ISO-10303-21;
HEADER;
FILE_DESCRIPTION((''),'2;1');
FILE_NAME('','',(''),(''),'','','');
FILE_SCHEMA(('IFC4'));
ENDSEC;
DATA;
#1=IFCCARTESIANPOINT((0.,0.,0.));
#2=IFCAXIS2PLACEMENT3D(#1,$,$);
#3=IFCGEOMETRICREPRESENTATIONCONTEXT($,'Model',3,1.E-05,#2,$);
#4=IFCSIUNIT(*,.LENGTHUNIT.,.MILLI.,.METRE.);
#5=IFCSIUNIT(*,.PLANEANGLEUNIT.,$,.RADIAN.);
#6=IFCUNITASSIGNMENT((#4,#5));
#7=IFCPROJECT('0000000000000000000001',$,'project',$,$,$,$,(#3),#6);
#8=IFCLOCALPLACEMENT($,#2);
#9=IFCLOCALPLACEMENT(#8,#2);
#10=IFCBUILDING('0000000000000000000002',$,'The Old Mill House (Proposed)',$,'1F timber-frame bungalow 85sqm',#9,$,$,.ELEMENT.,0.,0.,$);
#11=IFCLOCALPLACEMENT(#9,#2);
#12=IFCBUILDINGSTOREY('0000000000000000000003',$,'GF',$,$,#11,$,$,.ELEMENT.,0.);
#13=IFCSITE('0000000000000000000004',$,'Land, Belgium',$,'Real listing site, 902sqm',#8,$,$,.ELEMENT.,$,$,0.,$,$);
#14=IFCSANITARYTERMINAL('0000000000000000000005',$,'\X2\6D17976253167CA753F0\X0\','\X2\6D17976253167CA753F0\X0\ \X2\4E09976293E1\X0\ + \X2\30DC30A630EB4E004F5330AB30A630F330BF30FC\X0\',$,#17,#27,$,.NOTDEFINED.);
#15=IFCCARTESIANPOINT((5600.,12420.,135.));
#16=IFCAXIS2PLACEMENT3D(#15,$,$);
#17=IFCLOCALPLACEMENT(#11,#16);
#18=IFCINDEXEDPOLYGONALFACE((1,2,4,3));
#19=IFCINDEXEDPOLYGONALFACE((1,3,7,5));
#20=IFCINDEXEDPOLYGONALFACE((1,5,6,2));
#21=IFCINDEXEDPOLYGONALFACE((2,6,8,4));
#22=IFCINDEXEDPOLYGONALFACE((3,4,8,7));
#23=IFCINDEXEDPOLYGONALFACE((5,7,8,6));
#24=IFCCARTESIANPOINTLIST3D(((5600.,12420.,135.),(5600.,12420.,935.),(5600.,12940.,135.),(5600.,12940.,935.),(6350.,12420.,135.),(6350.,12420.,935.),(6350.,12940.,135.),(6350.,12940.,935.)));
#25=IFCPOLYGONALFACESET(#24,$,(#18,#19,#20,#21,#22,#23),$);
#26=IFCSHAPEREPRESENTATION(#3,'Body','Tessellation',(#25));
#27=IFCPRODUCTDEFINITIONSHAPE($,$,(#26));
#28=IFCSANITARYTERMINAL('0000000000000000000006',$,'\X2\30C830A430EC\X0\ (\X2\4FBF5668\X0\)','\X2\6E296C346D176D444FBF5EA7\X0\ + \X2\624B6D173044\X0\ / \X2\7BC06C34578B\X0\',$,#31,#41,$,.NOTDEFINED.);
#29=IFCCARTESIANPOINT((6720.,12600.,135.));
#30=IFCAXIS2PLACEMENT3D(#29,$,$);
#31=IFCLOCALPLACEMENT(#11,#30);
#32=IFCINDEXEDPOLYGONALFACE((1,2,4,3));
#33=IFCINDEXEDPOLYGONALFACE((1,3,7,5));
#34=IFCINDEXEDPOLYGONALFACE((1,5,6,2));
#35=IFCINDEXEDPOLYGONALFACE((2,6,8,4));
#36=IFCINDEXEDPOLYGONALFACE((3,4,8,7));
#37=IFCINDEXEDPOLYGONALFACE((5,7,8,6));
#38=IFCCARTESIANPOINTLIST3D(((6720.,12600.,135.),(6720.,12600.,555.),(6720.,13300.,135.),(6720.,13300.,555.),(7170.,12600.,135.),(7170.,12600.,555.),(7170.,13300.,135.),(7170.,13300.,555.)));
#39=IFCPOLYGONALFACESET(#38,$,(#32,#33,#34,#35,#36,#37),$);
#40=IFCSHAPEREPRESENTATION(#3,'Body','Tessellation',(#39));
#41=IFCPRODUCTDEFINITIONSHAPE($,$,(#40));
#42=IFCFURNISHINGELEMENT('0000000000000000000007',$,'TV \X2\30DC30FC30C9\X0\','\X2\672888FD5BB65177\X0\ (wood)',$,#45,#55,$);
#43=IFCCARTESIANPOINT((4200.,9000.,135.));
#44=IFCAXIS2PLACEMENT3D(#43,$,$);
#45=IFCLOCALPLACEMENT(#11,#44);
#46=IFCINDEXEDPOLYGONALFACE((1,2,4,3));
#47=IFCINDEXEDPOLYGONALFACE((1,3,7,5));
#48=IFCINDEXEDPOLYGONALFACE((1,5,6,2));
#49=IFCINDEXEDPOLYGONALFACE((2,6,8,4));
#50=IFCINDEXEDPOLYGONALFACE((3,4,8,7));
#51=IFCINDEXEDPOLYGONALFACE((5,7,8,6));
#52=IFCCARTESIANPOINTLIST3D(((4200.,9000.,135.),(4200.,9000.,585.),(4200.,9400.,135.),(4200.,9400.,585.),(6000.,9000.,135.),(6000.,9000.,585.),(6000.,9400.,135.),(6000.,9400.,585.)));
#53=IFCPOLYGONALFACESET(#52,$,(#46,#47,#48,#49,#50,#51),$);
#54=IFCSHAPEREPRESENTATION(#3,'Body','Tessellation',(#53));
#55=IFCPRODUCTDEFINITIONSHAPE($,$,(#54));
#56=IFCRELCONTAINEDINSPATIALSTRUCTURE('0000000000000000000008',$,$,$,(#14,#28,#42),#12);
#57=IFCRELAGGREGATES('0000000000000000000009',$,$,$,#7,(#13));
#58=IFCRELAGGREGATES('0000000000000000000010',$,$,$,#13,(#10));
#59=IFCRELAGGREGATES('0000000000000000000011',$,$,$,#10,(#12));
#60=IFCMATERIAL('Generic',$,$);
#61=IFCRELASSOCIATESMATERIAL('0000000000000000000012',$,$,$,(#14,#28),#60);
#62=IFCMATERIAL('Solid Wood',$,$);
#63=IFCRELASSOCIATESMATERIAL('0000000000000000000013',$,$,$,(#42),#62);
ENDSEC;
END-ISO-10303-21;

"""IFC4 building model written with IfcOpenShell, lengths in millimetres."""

from ifc_helpers import new_model, si_unit, frame, frame_2d, origin, place, context, project, spatial, rectangle, extrude, material, element, save


model = new_model("IFC4")

# Units and contexts
model_context = context("Model", 3, precision=1e-05, world=origin())
ifc_project = project(units=[si_unit("LENGTHUNIT", "METRE", prefix="MILLI"), si_unit("PLANEANGLEUNIT", "RADIAN")], contexts=[model_context])

# Site, building, storey
site_placement = place(None, origin())
site = spatial("IfcSite", under=ifc_project, at=site_placement, Name="Land, Belgium", ObjectType="Real listing site, 902sqm", CompositionType="ELEMENT", RefElevation=0.0)
building_placement = place(site_placement, origin())
building = spatial("IfcBuilding", under=site, at=building_placement, Name="The Old Mill House (Proposed)", ObjectType="1F timber-frame bungalow 85sqm", CompositionType="ELEMENT", ElevationOfRefHeight=0.0, ElevationOfTerrain=0.0)
storey_placement = place(building_placement, origin())
storey = spatial("IfcBuildingStorey", under=building, at=storey_placement, Name="GF", CompositionType="ELEMENT", Elevation=0.0)

# Shared definitions
ifc_material_1 = material(Name="Solid Wood")

# Shared definitions
ifc_material_2 = material(Name="Generic")

# Sanitary terminals
sanitary_terminal_1_placement = place(storey_placement, frame((5600.0, 12420.0, 135.0)))
element("IfcSanitaryTerminal", 1, at=sanitary_terminal_1_placement, inside=storey, material=ifc_material_2, Name="洗面化粧台", Description="洗面化粧台 三面鏡 + ボウル一体カウンター", PredefinedType="NOTDEFINED", context=model_context, shape_type="SweptSolid", body=[
    extrude(rectangle(XDim=750.0, YDim=520.0, at=frame_2d((375.0, 260.0))), frame((5600.0, 12420.0, 135.0)), (0.0, 0.0, 1.0), 800.0),
])
sanitary_terminal_2_placement = place(storey_placement, frame((6720.0, 12600.0, 135.0)))
element("IfcSanitaryTerminal", 2, at=sanitary_terminal_2_placement, inside=storey, material=ifc_material_2, Name="トイレ (便器)", Description="温水洗浄便座 + 手洗い / 節水型", PredefinedType="NOTDEFINED", context=model_context, shape_type="SweptSolid", body=[
    extrude(rectangle(XDim=450.0, YDim=700.0, at=frame_2d((225.0, 350.0))), frame((6720.0, 12600.0, 135.0)), (0.0, 0.0, 1.0), 420.0),
])

# Furnishing element
furnishing_placement = place(storey_placement, frame((4200.0, 9000.0, 135.0)))
element("IfcFurnishingElement", 3, at=furnishing_placement, inside=storey, material=ifc_material_1, Name="TV ボード", Description="木製家具 (wood)", context=model_context, shape_type="SweptSolid", body=[
    extrude(rectangle(XDim=1800.0, YDim=400.0, at=frame_2d((900.0, 200.0))), frame((4200.0, 9000.0, 135.0)), (0.0, 0.0, 1.0), 450.0),
])

save(model, "model.ifc")
